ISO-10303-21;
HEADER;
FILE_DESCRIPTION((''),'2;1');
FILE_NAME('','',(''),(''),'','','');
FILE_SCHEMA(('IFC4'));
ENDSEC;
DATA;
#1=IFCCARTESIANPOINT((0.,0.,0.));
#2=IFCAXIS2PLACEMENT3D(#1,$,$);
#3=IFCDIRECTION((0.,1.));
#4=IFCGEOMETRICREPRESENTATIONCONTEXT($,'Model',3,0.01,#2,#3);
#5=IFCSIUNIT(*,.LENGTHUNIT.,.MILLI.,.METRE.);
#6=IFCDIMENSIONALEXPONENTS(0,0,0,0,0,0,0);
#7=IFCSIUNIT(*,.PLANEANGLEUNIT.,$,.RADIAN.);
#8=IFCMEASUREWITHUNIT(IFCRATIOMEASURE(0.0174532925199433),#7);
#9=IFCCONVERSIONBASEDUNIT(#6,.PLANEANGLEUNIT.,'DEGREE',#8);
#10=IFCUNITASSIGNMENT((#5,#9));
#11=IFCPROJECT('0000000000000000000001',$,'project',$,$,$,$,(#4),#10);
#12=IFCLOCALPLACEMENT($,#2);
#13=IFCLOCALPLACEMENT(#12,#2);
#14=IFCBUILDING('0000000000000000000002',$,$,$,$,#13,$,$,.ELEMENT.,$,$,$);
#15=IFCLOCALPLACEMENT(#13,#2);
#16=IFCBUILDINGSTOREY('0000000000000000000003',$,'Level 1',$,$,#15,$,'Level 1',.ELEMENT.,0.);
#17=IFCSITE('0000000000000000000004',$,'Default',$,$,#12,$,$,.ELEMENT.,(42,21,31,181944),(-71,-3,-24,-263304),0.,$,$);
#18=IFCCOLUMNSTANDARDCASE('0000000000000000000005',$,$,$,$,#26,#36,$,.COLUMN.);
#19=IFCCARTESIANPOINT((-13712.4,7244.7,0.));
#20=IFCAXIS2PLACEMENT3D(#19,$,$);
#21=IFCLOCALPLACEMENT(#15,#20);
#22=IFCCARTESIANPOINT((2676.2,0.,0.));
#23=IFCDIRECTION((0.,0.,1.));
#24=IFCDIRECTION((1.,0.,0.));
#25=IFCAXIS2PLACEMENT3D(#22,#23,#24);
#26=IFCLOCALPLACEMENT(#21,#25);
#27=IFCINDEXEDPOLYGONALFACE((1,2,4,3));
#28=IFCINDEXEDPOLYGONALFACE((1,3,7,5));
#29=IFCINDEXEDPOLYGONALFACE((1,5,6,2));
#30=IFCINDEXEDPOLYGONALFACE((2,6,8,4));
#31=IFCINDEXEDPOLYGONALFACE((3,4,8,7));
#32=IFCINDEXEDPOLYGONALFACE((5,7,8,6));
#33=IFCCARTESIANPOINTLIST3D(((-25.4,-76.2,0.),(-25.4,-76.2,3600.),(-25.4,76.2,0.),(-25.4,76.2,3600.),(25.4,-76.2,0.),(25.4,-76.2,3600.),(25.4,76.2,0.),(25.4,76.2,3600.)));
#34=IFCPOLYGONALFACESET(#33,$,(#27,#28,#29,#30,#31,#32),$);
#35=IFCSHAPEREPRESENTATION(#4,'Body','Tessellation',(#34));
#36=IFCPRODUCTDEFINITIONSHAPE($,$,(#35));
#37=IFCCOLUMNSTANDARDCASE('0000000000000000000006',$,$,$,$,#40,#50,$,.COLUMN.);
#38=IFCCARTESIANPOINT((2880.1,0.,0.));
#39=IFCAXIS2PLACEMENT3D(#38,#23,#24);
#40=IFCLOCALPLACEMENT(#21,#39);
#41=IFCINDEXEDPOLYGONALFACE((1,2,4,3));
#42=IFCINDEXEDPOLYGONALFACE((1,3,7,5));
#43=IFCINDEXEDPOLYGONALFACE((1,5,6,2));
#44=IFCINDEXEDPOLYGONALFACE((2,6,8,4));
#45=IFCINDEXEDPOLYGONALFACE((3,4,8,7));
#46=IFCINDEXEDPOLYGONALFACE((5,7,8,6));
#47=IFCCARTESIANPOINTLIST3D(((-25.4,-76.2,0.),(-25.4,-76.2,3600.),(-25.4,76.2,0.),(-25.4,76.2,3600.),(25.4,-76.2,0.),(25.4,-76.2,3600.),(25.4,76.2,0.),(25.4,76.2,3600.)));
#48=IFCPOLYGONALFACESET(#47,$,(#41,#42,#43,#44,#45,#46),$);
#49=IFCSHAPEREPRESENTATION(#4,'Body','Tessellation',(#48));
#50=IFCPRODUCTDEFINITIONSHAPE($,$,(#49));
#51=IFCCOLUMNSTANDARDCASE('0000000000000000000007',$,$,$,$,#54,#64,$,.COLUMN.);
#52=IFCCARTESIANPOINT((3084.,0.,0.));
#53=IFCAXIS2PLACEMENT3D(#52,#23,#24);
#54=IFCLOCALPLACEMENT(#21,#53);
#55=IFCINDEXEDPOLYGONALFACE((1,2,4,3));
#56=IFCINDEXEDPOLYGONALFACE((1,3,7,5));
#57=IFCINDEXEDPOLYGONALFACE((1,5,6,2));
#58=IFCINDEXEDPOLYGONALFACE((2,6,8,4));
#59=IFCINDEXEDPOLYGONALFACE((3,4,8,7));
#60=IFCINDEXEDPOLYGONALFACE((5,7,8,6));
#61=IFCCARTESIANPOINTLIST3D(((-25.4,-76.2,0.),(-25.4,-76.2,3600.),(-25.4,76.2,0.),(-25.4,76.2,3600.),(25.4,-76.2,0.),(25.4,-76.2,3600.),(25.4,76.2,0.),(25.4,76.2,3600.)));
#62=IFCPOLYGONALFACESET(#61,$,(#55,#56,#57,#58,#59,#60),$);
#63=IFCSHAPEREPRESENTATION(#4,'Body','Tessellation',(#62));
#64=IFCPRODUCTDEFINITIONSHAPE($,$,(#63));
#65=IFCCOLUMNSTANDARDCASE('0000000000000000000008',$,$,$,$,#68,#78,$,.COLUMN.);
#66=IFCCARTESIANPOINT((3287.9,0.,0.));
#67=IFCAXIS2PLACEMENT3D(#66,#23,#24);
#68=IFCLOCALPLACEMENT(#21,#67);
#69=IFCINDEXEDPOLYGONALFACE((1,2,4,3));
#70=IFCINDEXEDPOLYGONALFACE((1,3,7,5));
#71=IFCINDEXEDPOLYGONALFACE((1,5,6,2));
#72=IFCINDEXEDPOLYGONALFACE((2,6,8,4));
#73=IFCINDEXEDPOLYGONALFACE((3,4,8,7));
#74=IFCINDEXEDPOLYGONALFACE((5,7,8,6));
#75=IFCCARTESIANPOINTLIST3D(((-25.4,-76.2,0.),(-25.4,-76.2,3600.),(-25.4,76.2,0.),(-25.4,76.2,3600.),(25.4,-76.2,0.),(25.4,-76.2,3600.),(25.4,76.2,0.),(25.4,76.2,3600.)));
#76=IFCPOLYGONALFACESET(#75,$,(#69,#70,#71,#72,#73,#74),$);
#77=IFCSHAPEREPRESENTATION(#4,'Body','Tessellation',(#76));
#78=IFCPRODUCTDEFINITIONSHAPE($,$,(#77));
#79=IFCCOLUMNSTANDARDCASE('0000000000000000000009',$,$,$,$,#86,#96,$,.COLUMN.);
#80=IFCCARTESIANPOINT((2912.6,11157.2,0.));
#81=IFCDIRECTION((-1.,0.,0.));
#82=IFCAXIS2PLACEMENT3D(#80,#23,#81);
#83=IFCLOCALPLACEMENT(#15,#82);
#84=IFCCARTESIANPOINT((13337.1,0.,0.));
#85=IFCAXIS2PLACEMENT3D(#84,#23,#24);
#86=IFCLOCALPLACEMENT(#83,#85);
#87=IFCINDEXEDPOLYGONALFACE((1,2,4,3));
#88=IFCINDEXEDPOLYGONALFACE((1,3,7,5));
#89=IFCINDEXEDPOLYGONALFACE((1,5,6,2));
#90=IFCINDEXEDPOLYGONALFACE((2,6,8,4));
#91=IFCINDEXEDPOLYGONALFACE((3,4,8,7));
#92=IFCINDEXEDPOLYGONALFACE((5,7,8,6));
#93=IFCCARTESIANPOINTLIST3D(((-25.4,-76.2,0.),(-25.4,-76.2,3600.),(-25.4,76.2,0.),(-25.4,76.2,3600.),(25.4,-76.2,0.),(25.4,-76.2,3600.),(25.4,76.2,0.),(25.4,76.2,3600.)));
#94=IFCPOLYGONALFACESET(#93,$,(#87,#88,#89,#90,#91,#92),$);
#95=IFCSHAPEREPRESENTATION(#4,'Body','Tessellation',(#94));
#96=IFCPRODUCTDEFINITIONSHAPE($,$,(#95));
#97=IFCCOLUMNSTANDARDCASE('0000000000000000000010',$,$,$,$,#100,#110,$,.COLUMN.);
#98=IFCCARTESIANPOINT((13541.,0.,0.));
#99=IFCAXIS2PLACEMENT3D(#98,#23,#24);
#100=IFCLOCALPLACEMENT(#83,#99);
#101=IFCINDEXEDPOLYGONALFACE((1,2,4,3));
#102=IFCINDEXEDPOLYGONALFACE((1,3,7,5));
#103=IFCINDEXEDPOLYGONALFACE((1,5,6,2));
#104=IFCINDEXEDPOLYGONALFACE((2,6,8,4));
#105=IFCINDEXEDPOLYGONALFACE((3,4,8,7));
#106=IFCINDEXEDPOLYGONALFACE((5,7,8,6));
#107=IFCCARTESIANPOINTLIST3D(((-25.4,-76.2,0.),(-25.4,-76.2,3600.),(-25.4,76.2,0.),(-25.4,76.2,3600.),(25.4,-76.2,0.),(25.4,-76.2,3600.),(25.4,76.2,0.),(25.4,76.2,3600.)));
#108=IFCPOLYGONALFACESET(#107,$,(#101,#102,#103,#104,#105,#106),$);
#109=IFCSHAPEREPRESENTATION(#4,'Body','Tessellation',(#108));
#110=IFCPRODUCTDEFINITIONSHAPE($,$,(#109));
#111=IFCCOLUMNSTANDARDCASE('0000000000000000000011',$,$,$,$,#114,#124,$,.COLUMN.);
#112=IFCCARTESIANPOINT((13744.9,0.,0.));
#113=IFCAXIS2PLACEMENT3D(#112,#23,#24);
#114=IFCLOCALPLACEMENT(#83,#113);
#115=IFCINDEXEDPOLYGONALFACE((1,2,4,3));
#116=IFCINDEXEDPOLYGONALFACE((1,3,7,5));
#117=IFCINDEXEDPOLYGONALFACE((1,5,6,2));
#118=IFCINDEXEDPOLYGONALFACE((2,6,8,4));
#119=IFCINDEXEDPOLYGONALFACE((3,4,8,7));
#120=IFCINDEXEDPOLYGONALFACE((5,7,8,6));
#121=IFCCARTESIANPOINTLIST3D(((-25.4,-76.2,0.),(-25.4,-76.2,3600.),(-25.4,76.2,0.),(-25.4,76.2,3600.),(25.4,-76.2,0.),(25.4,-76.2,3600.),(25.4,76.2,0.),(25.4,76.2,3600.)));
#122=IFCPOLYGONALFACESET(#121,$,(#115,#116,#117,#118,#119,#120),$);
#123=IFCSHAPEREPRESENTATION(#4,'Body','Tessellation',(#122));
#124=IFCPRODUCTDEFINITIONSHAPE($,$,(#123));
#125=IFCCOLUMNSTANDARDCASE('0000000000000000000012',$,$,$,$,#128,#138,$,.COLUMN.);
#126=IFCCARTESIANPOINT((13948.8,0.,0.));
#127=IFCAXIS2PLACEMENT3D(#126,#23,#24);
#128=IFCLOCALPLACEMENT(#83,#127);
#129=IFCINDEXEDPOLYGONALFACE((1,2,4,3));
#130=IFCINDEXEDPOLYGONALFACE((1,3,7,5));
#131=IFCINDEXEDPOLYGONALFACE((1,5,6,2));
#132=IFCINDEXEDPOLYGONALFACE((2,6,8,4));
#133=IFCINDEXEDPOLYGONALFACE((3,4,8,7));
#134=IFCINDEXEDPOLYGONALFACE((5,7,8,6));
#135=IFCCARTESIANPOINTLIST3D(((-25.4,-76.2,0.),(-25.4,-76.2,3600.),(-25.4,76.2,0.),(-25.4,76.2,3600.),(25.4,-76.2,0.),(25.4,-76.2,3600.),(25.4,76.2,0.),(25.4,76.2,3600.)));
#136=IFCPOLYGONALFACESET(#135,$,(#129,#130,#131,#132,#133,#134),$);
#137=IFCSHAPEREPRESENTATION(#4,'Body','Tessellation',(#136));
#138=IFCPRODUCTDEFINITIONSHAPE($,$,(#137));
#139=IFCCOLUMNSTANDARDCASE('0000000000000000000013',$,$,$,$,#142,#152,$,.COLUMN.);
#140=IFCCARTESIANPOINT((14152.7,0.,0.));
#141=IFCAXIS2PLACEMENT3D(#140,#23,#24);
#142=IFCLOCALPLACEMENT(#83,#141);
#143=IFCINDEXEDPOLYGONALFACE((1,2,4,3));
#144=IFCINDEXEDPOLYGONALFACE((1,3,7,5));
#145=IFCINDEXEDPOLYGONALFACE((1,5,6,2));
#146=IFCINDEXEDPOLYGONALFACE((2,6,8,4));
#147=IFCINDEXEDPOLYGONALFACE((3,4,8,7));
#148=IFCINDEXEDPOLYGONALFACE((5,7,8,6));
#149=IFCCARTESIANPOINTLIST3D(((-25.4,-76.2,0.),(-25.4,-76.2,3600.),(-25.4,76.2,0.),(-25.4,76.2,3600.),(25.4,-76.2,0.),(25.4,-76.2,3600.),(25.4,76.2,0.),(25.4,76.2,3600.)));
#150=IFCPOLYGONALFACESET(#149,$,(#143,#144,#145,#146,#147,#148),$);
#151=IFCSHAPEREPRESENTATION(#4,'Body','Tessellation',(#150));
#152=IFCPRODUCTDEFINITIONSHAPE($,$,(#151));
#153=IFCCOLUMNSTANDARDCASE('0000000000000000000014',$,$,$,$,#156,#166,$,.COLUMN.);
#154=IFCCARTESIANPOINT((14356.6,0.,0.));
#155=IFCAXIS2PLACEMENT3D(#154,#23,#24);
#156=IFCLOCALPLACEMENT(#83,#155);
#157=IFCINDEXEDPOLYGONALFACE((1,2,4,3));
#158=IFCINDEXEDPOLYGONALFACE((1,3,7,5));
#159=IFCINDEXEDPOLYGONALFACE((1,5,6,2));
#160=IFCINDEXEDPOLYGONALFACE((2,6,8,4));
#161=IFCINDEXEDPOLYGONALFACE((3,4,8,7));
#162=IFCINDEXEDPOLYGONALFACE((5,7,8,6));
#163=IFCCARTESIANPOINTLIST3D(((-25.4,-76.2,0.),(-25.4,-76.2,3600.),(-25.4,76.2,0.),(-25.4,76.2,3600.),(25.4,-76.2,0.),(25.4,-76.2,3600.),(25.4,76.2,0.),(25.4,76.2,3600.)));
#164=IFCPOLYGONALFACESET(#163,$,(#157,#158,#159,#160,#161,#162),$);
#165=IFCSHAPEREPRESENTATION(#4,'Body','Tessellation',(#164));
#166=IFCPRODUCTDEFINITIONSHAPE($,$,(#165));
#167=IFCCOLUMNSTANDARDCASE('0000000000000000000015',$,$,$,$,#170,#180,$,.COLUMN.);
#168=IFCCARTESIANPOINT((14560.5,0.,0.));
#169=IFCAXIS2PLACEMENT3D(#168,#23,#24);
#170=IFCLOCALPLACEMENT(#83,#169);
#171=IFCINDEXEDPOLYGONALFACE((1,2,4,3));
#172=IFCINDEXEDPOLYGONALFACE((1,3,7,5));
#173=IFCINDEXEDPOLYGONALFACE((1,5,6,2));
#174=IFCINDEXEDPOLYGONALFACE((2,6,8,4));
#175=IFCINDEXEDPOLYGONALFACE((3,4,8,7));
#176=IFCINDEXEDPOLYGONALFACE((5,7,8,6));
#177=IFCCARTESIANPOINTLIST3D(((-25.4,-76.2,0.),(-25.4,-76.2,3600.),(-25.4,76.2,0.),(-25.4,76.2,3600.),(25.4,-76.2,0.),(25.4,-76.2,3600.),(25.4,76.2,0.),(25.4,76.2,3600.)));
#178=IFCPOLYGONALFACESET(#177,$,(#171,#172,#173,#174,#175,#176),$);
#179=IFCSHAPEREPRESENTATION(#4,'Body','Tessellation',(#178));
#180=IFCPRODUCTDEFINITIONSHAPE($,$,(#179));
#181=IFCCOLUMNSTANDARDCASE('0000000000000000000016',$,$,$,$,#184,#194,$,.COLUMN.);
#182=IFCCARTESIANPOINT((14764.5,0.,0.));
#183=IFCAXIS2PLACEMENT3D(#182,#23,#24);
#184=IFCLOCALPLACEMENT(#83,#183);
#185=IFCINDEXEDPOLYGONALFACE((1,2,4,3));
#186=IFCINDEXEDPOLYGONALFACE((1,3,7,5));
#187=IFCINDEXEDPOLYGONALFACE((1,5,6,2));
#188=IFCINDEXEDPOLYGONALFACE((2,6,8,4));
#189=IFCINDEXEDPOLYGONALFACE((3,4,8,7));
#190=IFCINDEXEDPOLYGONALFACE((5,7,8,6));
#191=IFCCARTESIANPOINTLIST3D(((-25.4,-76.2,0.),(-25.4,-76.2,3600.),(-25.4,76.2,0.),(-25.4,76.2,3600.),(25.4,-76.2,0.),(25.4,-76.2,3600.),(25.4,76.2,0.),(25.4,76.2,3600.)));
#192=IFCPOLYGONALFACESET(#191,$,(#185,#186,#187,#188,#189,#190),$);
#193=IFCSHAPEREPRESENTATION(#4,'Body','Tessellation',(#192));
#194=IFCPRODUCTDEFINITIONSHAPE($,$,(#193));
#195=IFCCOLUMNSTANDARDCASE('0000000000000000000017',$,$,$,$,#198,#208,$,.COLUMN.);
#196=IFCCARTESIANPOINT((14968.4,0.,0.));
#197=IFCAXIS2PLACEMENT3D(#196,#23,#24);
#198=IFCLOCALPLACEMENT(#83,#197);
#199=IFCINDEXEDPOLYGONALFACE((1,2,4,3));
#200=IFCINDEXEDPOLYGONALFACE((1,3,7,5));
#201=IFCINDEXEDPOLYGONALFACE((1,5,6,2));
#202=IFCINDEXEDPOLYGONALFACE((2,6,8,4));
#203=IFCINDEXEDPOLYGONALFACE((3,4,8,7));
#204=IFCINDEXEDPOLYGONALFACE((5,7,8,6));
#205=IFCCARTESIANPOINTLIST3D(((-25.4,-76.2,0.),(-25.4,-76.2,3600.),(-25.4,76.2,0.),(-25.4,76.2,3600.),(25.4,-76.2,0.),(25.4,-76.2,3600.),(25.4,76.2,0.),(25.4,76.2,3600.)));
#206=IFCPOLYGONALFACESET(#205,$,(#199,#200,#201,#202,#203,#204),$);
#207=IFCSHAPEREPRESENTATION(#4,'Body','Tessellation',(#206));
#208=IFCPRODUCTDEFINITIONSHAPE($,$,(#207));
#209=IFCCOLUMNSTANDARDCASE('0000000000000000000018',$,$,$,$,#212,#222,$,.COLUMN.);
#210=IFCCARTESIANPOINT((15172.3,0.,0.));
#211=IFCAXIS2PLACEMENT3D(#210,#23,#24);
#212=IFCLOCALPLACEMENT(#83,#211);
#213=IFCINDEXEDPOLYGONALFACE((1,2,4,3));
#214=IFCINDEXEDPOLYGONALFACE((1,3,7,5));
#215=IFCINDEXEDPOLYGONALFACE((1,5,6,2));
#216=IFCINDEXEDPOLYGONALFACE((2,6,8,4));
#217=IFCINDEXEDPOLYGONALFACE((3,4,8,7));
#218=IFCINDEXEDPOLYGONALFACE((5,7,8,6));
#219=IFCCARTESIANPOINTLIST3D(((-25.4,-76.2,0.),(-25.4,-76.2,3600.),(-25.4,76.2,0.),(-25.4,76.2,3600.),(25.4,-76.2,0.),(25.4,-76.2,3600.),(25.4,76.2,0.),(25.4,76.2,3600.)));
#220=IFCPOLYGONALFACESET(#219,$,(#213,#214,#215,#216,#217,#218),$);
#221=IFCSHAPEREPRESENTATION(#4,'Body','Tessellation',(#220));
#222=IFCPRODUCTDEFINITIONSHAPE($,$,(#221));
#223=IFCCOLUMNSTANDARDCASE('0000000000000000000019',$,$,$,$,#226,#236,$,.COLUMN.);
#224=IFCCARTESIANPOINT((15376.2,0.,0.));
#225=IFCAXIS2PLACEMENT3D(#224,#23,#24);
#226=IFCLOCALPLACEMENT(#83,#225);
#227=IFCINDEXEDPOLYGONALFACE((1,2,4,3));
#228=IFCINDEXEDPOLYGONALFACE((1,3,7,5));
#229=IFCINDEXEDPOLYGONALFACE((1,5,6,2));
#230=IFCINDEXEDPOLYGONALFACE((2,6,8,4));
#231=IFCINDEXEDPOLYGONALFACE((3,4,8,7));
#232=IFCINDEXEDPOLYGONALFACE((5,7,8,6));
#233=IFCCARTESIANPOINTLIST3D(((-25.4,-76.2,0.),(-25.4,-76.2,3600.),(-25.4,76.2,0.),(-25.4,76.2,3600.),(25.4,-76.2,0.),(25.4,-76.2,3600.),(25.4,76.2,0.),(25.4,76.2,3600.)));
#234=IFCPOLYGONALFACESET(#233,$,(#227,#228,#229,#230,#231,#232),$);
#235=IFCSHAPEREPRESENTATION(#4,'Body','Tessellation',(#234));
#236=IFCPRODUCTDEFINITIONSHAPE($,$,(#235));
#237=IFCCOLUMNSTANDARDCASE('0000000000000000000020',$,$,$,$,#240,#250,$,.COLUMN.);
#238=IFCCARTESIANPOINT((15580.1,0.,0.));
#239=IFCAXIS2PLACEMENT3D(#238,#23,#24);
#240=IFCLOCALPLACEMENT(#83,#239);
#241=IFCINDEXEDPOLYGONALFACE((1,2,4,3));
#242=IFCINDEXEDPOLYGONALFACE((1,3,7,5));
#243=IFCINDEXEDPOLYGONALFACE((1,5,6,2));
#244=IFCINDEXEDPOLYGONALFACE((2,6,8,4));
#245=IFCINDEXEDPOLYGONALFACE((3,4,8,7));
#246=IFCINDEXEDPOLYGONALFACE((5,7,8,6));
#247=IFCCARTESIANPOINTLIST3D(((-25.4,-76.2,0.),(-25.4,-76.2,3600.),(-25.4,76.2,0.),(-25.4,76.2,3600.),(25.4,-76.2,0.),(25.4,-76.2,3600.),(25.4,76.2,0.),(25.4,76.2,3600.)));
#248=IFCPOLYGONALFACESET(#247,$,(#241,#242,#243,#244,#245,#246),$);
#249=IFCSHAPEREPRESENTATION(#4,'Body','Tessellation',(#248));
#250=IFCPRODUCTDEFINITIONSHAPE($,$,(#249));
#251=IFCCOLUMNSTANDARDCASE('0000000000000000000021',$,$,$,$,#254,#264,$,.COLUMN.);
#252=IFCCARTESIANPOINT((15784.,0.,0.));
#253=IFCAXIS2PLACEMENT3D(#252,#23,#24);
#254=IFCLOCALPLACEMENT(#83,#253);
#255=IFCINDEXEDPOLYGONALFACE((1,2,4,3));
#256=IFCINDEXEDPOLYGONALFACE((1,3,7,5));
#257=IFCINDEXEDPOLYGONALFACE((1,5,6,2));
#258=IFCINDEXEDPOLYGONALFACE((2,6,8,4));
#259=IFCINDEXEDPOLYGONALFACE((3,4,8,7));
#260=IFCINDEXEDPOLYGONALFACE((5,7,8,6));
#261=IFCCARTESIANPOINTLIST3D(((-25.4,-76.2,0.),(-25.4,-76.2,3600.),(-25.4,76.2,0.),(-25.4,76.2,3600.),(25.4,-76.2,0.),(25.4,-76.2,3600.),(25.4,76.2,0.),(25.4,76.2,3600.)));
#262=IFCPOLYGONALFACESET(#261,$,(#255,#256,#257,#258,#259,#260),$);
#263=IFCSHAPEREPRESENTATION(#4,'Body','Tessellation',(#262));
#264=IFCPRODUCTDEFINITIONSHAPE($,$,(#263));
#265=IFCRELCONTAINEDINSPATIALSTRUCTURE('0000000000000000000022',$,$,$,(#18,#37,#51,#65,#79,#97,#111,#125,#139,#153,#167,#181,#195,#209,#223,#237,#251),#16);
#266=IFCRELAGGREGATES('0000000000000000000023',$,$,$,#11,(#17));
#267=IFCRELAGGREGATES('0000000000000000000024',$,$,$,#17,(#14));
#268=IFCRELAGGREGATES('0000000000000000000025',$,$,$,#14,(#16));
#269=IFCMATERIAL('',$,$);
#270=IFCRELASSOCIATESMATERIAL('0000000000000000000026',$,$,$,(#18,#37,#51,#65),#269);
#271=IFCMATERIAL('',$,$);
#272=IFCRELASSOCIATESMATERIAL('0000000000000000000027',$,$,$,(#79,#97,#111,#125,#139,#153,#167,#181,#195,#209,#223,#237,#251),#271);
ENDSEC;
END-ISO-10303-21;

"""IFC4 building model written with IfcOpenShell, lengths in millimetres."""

from ifc_helpers import new_model, entity, si_unit, converted_unit, direction, frame, origin, place, context, project, spatial, rectangle, extrude, material, element, save


model = new_model("IFC4")

# Units and contexts
model_context = context("Model", 3, precision=0.01, world=origin(), true_north=direction((0.0, 1.0)))
ifc_project = project(units=[si_unit("LENGTHUNIT", "METRE", prefix="MILLI"), converted_unit("PLANEANGLEUNIT", "DEGREE", entity("IfcRatioMeasure", 0.0174532925199433), si_unit("PLANEANGLEUNIT", "RADIAN"), dimensions=[0, 0, 0, 0, 0, 0, 0])], contexts=[model_context])

# Site, building, storey
site_placement = place(None, origin())
site = spatial("IfcSite", under=ifc_project, at=site_placement, Name="Default", CompositionType="ELEMENT", RefLatitude=(42, 21, 31, 181944), RefLongitude=(-71, -3, -24, -263304), RefElevation=0.0)
building_placement = place(site_placement, origin())
building = spatial("IfcBuilding", under=site, at=building_placement, CompositionType="ELEMENT")
storey_placement = place(building_placement, origin())
storey = spatial("IfcBuildingStorey", under=building, at=storey_placement, Name="Level 1", LongName="Level 1", CompositionType="ELEMENT", Elevation=0.0)

# Columns
ifc_material_1 = material(Name="")
placement_1 = place(storey_placement, frame((-13712.4, 7244.7, 0.0)))
for number, where, z_axis, x_axis in (
    (1, (2676.2, 0.0, 0.0), (0.0, 0.0, 1.0), (1.0, 0.0, 0.0)),
    (2, (2880.1, 0.0, 0.0), (0.0, 0.0, 1.0), (1.0, 0.0, 0.0)),
    (3, (3084.0, 0.0, 0.0), (0.0, 0.0, 1.0), (1.0, 0.0, 0.0)),
    (4, (3287.9, 0.0, 0.0), (0.0, 0.0, 1.0), (1.0, 0.0, 0.0)),
):
    element("IfcColumnStandardCase", number, at=place(placement_1, frame(where, z_axis=z_axis, x_axis=x_axis)), inside=storey, material=ifc_material_1, PredefinedType="COLUMN", context=model_context, shape_type="SweptSolid", body=[
        extrude(rectangle(XDim=50.8, YDim=152.4), origin(), (0.0, 0.0, 1.0), 3600.0),
    ])
ifc_material_2 = material(Name="")
placement_2 = place(storey_placement, frame((2912.6, 11157.2, 0.0), z_axis=(0.0, 0.0, 1.0), x_axis=(-1.0, 0.0, 0.0)))
for number, where, z_axis, x_axis in (
    (5, (13337.1, 0.0, 0.0), (0.0, 0.0, 1.0), (1.0, 0.0, 0.0)),
    (6, (13541.0, 0.0, 0.0), (0.0, 0.0, 1.0), (1.0, 0.0, 0.0)),
    (7, (13744.9, 0.0, 0.0), (0.0, 0.0, 1.0), (1.0, 0.0, 0.0)),
    (8, (13948.8, 0.0, 0.0), (0.0, 0.0, 1.0), (1.0, 0.0, 0.0)),
    (9, (14152.7, 0.0, 0.0), (0.0, 0.0, 1.0), (1.0, 0.0, 0.0)),
    (10, (14356.6, 0.0, 0.0), (0.0, 0.0, 1.0), (1.0, 0.0, 0.0)),
    (11, (14560.5, 0.0, 0.0), (0.0, 0.0, 1.0), (1.0, 0.0, 0.0)),
    (12, (14764.5, 0.0, 0.0), (0.0, 0.0, 1.0), (1.0, 0.0, 0.0)),
    (13, (14968.4, 0.0, 0.0), (0.0, 0.0, 1.0), (1.0, 0.0, 0.0)),
    (14, (15172.3, 0.0, 0.0), (0.0, 0.0, 1.0), (1.0, 0.0, 0.0)),
    (15, (15376.2, 0.0, 0.0), (0.0, 0.0, 1.0), (1.0, 0.0, 0.0)),
    (16, (15580.1, 0.0, 0.0), (0.0, 0.0, 1.0), (1.0, 0.0, 0.0)),
    (17, (15784.0, 0.0, 0.0), (0.0, 0.0, 1.0), (1.0, 0.0, 0.0)),
):
    element("IfcColumnStandardCase", number, at=place(placement_2, frame(where, z_axis=z_axis, x_axis=x_axis)), inside=storey, material=ifc_material_2, PredefinedType="COLUMN", context=model_context, shape_type="SweptSolid", body=[
        extrude(rectangle(XDim=50.8, YDim=152.4), origin(), (0.0, 0.0, 1.0), 3600.0),
    ])

save(model, "model.ifc")
